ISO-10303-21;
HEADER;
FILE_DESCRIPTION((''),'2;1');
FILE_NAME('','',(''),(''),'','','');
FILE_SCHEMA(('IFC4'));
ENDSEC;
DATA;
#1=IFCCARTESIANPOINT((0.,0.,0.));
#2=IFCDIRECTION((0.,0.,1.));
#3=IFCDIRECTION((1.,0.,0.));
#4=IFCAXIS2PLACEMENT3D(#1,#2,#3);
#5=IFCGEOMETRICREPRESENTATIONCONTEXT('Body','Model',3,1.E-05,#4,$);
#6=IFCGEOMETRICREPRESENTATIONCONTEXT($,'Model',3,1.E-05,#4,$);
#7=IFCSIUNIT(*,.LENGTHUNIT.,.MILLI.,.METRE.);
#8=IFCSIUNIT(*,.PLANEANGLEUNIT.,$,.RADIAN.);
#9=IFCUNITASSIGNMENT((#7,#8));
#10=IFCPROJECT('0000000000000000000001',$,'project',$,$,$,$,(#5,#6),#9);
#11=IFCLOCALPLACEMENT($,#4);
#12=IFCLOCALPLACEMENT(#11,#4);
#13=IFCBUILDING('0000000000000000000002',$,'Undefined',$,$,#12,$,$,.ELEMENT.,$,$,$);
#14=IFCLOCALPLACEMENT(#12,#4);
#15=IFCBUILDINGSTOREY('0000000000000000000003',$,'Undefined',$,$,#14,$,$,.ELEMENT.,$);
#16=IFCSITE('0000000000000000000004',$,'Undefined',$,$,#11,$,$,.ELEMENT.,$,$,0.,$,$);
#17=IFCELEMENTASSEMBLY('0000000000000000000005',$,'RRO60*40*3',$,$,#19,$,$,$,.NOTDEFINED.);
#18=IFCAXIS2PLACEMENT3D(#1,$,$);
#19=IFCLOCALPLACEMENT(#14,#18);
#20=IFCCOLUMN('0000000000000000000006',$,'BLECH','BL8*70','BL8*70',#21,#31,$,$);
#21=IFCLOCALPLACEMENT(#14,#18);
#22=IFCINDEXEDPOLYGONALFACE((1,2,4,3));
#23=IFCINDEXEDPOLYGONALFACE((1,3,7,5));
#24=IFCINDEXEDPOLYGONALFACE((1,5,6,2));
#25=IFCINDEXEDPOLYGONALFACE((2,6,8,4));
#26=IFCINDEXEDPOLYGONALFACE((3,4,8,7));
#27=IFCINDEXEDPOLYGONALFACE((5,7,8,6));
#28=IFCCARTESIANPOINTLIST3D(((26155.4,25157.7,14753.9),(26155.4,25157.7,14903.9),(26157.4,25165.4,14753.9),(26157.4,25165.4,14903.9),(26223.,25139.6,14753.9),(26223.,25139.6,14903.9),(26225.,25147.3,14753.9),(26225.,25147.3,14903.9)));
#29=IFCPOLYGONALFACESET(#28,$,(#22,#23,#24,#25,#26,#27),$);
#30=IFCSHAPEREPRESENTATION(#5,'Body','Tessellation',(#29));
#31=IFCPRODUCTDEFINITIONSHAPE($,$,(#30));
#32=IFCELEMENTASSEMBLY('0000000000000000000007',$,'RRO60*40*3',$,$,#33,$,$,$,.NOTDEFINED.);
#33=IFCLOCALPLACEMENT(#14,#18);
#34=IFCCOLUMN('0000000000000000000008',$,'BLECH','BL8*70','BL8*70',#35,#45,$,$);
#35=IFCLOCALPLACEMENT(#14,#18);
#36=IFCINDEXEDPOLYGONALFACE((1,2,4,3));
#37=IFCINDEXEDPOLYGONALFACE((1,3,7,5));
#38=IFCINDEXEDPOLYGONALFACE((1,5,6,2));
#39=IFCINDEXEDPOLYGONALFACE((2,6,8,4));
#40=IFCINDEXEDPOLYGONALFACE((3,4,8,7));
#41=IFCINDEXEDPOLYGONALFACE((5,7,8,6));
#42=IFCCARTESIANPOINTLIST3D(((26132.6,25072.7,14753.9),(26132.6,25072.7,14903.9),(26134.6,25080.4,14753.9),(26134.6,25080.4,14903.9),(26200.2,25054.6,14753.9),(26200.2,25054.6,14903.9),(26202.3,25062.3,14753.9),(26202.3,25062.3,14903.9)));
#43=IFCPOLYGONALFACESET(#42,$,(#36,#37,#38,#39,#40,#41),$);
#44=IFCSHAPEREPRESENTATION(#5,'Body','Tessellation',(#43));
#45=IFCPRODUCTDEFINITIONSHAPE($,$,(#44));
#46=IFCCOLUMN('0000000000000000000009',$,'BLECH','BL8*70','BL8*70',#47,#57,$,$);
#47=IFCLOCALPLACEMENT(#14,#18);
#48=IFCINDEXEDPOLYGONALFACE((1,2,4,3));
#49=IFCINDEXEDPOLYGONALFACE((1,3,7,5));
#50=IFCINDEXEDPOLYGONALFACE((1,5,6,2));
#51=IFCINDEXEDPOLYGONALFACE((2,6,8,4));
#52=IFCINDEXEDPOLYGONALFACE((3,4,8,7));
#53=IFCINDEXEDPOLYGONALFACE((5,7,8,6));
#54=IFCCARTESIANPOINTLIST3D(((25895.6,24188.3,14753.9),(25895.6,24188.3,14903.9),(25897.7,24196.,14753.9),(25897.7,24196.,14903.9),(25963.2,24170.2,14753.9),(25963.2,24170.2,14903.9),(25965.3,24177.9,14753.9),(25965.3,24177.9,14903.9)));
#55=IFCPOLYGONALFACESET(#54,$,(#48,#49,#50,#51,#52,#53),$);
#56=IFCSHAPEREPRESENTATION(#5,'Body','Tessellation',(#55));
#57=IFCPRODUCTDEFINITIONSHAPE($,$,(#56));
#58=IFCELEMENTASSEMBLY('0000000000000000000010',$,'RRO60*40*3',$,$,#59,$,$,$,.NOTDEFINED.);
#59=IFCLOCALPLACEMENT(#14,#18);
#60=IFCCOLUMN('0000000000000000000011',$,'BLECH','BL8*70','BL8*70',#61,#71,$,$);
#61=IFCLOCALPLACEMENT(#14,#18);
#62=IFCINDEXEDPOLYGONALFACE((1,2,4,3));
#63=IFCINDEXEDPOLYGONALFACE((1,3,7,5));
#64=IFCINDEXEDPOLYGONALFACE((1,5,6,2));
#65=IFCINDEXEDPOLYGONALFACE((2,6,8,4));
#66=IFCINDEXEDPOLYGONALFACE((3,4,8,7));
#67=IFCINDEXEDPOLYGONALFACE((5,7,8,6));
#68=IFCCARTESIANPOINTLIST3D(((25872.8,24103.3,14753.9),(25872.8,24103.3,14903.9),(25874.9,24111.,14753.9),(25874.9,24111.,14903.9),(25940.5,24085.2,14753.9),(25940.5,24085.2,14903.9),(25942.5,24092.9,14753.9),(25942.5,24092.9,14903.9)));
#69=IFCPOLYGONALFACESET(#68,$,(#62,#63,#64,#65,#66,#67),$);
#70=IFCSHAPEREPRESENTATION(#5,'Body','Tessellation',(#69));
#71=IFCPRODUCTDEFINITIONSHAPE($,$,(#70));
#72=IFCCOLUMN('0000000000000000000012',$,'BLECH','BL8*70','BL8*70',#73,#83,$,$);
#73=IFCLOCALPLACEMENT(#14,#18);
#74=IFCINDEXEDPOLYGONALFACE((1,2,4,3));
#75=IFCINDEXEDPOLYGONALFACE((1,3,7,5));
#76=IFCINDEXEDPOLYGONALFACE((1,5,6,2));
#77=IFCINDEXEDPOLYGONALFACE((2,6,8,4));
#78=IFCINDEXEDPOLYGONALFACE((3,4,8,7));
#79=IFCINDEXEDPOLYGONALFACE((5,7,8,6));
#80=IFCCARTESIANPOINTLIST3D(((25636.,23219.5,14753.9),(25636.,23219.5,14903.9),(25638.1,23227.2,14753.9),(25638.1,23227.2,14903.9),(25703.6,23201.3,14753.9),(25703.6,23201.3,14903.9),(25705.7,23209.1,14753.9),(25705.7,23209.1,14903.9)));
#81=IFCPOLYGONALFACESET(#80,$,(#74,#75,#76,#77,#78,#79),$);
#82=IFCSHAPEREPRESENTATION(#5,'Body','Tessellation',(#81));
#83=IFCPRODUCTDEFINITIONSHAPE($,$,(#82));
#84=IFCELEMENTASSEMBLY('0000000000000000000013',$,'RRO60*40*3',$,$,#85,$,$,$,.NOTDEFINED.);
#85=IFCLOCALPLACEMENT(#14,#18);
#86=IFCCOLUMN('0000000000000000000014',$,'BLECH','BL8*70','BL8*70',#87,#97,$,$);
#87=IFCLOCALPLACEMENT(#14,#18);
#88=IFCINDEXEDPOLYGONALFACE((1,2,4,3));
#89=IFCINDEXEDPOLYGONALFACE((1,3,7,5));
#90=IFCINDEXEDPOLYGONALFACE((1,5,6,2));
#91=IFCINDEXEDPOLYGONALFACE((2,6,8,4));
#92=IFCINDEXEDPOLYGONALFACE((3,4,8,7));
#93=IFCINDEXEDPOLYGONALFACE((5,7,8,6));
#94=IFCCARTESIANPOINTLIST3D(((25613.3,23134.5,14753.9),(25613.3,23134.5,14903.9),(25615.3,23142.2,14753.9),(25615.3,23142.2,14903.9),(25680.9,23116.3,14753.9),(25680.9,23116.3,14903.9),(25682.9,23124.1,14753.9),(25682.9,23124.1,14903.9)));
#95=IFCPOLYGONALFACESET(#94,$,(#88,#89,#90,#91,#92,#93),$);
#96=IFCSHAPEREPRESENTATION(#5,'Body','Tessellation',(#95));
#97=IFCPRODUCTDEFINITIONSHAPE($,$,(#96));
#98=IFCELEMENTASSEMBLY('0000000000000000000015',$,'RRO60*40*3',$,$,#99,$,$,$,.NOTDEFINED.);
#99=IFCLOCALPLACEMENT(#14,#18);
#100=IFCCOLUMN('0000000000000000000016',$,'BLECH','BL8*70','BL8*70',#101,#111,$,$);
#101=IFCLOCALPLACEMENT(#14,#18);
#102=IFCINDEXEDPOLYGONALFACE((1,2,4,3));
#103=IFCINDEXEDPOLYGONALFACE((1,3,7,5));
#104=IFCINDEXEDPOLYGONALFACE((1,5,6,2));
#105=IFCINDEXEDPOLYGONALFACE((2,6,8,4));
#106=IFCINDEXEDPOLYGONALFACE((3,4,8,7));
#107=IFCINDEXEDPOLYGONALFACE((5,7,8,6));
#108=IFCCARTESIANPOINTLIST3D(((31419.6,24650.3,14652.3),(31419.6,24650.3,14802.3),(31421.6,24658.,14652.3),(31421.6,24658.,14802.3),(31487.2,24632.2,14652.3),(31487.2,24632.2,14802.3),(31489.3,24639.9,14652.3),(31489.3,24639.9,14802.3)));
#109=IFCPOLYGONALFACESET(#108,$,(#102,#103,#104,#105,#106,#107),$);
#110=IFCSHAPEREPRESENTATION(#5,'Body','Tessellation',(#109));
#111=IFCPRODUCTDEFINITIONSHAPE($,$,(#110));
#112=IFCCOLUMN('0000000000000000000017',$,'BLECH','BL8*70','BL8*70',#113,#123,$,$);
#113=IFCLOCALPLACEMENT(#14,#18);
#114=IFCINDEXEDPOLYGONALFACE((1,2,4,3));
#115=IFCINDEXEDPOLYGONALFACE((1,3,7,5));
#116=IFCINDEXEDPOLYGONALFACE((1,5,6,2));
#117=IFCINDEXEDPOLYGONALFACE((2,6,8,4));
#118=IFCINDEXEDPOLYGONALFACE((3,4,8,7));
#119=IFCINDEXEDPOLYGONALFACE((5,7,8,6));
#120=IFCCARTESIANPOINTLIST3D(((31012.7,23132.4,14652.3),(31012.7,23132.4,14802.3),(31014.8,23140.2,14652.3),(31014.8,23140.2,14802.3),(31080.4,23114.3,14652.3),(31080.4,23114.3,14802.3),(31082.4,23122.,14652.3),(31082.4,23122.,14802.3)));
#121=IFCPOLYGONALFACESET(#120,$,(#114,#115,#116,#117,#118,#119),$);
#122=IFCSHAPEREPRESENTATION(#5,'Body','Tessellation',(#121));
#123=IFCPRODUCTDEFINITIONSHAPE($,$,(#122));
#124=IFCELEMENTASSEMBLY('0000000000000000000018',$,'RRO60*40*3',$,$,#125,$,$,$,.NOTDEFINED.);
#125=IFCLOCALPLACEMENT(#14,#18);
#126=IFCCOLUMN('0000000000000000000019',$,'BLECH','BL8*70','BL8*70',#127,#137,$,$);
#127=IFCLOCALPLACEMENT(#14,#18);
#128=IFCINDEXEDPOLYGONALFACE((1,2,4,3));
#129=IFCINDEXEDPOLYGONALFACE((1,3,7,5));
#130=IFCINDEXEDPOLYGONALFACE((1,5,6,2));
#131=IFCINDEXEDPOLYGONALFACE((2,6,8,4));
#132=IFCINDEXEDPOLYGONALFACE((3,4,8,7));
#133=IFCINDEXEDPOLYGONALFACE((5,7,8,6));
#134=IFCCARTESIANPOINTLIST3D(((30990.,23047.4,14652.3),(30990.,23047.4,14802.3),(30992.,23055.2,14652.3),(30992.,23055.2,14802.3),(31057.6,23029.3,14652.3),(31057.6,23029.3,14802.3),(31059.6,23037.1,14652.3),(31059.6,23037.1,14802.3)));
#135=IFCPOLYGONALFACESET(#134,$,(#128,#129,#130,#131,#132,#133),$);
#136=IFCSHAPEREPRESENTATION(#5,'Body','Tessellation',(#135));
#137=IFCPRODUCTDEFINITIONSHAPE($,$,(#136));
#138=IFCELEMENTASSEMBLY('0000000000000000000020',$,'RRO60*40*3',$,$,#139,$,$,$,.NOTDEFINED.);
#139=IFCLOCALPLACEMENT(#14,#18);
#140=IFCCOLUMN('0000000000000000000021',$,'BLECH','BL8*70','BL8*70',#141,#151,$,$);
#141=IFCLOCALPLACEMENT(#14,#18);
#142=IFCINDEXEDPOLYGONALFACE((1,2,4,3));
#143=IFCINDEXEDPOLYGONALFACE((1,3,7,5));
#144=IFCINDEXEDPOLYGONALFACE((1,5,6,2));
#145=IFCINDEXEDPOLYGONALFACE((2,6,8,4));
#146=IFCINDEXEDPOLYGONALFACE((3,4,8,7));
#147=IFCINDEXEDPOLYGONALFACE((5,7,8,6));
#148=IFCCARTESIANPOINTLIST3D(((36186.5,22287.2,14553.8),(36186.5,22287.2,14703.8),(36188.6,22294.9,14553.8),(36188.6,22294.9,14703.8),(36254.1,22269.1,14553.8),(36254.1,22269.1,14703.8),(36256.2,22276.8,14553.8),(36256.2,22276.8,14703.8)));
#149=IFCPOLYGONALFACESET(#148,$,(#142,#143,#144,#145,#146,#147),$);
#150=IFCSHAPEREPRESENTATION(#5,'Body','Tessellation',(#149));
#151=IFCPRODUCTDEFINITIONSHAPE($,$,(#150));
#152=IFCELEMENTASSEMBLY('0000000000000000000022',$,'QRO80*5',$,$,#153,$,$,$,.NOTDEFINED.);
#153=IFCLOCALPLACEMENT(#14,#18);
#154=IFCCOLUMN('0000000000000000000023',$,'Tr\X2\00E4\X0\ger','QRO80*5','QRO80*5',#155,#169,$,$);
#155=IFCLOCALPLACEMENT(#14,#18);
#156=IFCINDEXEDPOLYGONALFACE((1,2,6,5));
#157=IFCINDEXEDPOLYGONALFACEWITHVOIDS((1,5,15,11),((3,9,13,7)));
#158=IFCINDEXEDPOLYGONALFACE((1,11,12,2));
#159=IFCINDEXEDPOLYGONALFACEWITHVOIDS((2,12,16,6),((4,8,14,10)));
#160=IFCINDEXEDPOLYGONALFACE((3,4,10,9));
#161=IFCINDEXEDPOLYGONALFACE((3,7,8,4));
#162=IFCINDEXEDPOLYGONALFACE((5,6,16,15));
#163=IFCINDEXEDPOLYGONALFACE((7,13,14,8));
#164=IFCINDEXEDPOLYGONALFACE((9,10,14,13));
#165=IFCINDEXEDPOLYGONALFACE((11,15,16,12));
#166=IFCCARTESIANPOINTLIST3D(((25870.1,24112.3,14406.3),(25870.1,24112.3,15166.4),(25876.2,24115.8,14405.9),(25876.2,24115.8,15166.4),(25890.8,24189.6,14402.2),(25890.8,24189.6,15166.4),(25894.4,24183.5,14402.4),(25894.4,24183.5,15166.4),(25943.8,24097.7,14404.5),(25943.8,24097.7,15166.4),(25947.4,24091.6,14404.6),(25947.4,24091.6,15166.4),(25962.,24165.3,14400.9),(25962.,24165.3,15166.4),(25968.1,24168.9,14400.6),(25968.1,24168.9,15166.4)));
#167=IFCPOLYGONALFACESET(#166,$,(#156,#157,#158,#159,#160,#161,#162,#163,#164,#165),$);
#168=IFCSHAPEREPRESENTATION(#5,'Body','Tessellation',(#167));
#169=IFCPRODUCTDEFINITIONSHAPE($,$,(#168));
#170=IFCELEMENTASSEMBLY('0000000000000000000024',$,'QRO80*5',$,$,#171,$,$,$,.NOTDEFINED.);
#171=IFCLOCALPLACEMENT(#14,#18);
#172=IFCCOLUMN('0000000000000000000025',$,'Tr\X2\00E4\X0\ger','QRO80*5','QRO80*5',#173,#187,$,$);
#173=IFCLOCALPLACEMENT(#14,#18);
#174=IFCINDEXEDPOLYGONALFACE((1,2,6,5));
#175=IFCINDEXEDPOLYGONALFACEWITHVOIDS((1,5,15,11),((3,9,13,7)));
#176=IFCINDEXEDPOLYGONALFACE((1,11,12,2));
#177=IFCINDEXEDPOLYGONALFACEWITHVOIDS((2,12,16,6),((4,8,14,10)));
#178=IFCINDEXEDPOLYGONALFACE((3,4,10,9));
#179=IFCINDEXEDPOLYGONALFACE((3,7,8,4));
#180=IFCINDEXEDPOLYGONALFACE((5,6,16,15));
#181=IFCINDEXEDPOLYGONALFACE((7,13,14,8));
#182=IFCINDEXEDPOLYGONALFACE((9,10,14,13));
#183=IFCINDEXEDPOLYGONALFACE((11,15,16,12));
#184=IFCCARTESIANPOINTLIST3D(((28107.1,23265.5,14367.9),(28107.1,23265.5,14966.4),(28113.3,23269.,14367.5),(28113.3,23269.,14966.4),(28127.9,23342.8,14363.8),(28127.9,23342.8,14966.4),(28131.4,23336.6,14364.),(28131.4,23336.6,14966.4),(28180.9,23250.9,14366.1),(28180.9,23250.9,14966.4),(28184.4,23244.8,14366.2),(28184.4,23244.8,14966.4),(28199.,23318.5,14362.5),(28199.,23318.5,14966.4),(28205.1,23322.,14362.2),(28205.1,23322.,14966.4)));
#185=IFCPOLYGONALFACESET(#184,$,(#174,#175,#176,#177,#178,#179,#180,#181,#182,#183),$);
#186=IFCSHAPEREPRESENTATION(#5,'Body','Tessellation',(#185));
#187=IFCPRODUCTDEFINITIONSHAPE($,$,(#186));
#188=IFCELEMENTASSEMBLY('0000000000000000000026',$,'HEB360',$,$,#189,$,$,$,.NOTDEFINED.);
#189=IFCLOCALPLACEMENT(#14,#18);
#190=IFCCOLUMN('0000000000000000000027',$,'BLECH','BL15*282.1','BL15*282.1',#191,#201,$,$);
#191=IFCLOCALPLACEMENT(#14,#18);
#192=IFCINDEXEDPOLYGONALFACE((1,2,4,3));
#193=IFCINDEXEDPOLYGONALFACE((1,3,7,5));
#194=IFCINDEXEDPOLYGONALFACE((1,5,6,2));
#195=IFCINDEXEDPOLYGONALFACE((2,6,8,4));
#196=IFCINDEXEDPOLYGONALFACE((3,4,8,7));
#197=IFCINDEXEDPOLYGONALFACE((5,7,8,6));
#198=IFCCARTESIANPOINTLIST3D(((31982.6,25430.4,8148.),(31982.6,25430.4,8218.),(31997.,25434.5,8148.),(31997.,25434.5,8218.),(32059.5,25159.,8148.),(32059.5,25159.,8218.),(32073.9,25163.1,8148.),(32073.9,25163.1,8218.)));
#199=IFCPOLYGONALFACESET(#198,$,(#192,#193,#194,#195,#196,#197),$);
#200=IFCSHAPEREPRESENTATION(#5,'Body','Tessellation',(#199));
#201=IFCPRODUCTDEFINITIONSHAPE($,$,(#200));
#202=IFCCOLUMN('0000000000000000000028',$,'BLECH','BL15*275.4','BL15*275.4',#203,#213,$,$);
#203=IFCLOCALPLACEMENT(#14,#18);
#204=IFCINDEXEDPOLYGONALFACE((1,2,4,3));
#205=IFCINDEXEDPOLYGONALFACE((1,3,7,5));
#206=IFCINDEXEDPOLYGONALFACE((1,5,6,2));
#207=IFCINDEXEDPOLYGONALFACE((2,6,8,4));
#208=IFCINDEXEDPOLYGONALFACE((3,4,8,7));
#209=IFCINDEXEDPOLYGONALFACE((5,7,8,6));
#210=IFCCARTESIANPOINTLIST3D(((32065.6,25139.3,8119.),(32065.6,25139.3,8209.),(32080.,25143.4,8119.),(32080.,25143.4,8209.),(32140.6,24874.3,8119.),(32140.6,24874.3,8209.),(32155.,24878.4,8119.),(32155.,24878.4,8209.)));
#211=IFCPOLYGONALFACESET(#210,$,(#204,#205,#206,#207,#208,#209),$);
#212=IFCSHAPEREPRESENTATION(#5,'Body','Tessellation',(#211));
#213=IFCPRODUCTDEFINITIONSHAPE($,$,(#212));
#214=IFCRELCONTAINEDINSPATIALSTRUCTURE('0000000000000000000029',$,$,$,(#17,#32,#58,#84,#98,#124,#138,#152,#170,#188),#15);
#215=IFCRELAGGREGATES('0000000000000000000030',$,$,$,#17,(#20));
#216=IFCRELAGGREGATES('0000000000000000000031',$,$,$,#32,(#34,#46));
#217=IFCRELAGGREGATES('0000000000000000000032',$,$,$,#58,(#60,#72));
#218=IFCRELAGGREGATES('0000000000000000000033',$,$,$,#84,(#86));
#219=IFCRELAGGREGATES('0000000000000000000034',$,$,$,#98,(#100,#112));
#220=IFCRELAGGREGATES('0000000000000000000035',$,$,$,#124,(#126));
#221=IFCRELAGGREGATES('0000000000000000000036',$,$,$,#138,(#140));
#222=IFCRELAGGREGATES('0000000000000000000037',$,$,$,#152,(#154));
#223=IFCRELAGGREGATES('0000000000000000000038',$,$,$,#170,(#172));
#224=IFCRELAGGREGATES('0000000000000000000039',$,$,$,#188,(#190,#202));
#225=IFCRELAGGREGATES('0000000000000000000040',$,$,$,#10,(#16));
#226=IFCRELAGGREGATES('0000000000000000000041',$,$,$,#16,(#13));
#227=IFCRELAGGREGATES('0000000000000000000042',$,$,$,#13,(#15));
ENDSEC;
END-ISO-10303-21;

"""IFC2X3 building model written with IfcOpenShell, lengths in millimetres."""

from ifc_helpers import new_model, si_unit, frame, origin_with_axes, origin_2d_with_axis, place, context, project, spatial, rectangle, hollow_rectangle, extrude, clip, halfspace, element, aggregate, save


model = new_model("IFC2X3")

# Units and contexts
model_context_1 = context("Model", 3, precision=1e-05, world=origin_with_axes(), identifier="Body")
model_context_2 = context("Model", 3, precision=1e-05, world=origin_with_axes())
ifc_project = project(units=[si_unit("LENGTHUNIT", "METRE", prefix="MILLI"), si_unit("PLANEANGLEUNIT", "RADIAN")], contexts=[model_context_1, model_context_2])

# Site, building, storey
site_placement = place(None, origin_with_axes())
site = spatial("IfcSite", under=ifc_project, at=site_placement, Name="Undefined", CompositionType="ELEMENT", RefElevation=0.0)
building_placement = place(site_placement, origin_with_axes())
building = spatial("IfcBuilding", under=site, at=building_placement, Name="Undefined", CompositionType="ELEMENT")
storey_placement = place(building_placement, origin_with_axes())
storey = spatial("IfcBuildingStorey", under=building, at=storey_placement, Name="Undefined", CompositionType="ELEMENT")

# Element assembly, column
assembly_1 = element("IfcElementAssembly", 1, inside=storey, Name="RRO60*40*3", PredefinedType="NOTDEFINED")
column_1_placement = place(storey_placement, frame((26190.2, 25152.5, 14753.9), z_axis=(0.0, 0.0, 1.0), x_axis=(1.0, 0.0, 0.0)))
column_1 = element("IfcColumn", 2, at=column_1_placement, Name="BLECH", Description="BL8*70", ObjectType="BL8*70", context=model_context_1, shape_type="SweptSolid", body=[
    extrude(rectangle(XDim=8.0, YDim=70.0, at=origin_2d_with_axis()), frame((0.0, 0.0, 150.0), z_axis=(0.0, 0.0, -1.0), x_axis=(0.258815, 0.965927, 0.000003)), (0.0, 0.0, 1.0), 150.0),
])
aggregate(assembly_1, [column_1])

# Element assemblies, columns
assembly_2 = element("IfcElementAssembly", 3, inside=storey, Name="RRO60*40*3", PredefinedType="NOTDEFINED")
column_2_placement = place(storey_placement, frame((26167.4, 25067.5, 14753.9), z_axis=(0.0, 0.0, 1.0), x_axis=(1.0, 0.0, 0.0)))
column_2 = element("IfcColumn", 4, at=column_2_placement, Name="BLECH", Description="BL8*70", ObjectType="BL8*70", context=model_context_1, shape_type="SweptSolid", body=[
    extrude(rectangle(XDim=8.0, YDim=70.0, at=origin_2d_with_axis()), frame((0.0, 0.0, 150.0), z_axis=(0.0, 0.0, -1.0), x_axis=(-0.258794, -0.965933, -0.000003)), (0.0, 0.0, 1.0), 150.0),
])
column_3_placement = place(storey_placement, frame((25930.5, 24183.1, 14753.9), z_axis=(0.0, 0.0, 1.0), x_axis=(1.0, 0.0, 0.0)))
column_3 = element("IfcColumn", 5, at=column_3_placement, Name="BLECH", Description="BL8*70", ObjectType="BL8*70", context=model_context_1, shape_type="SweptSolid", body=[
    extrude(rectangle(XDim=8.0, YDim=70.0, at=origin_2d_with_axis()), frame((0.0, 0.0, 150.0), z_axis=(0.0, 0.0, -1.0), x_axis=(0.258794, 0.965933, 0.000003)), (0.0, 0.0, 1.0), 150.0),
])
aggregate(assembly_2, [column_2, column_3])
assembly_3 = element("IfcElementAssembly", 6, inside=storey, Name="RRO60*40*3", PredefinedType="NOTDEFINED")
column_4_placement = place(storey_placement, frame((25907.7, 24098.1, 14753.9), z_axis=(0.0, 0.0, 1.0), x_axis=(1.0, 0.0, 0.0)))
column_4 = element("IfcColumn", 7, at=column_4_placement, Name="BLECH", Description="BL8*70", ObjectType="BL8*70", context=model_context_1, shape_type="SweptSolid", body=[
    extrude(rectangle(XDim=8.0, YDim=70.0, at=origin_2d_with_axis()), frame((0.0, 0.0, 150.0), z_axis=(0.0, 0.0, -1.0), x_axis=(-0.258815, -0.965927, -0.000003)), (0.0, 0.0, 1.0), 150.0),
])
column_5_placement = place(storey_placement, frame((25670.9, 23214.3, 14753.9), z_axis=(0.0, 0.0, 1.0), x_axis=(1.0, 0.0, 0.0)))
column_5 = element("IfcColumn", 8, at=column_5_placement, Name="BLECH", Description="BL8*70", ObjectType="BL8*70", context=model_context_1, shape_type="SweptSolid", body=[
    extrude(rectangle(XDim=8.0, YDim=70.0, at=origin_2d_with_axis()), frame((0.0, 0.0, 150.0), z_axis=(0.0, 0.0, -1.0), x_axis=(0.258815, 0.965927, 0.000003)), (0.0, 0.0, 1.0), 150.0),
])
aggregate(assembly_3, [column_4, column_5])

# Element assembly, column
assembly_4 = element("IfcElementAssembly", 9, inside=storey, Name="RRO60*40*3", PredefinedType="NOTDEFINED")
column_6_placement = place(storey_placement, frame((25648.1, 23129.3, 14753.9), z_axis=(0.0, 0.0, 1.0), x_axis=(1.0, 0.0, 0.0)))
column_6 = element("IfcColumn", 10, at=column_6_placement, Name="BLECH", Description="BL8*70", ObjectType="BL8*70", context=model_context_1, shape_type="SweptSolid", body=[
    extrude(rectangle(XDim=8.0, YDim=70.0, at=origin_2d_with_axis()), frame((0.0, 0.0, 150.0), z_axis=(0.0, 0.0, -1.0), x_axis=(-0.258752, -0.965944, -0.000003)), (0.0, 0.0, 1.0), 150.0),
])
aggregate(assembly_4, [column_6])

# Element assembly, columns
assembly_5 = element("IfcElementAssembly", 11, inside=storey, Name="RRO60*40*3", PredefinedType="NOTDEFINED")
column_7_placement = place(storey_placement, frame((31454.4, 24645.1, 14652.3), z_axis=(0.0, 0.0, 1.0), x_axis=(1.0, 0.0, 0.0)))
column_7 = element("IfcColumn", 12, at=column_7_placement, Name="BLECH", Description="BL8*70", ObjectType="BL8*70", context=model_context_1, shape_type="SweptSolid", body=[
    extrude(rectangle(XDim=8.0, YDim=70.0, at=origin_2d_with_axis()), frame((0.0, 0.0, 150.0), z_axis=(0.0, 0.0, -1.0), x_axis=(-0.258894, -0.965906, 0.000004)), (0.0, 0.0, 1.0), 150.0),
])
column_8_placement = place(storey_placement, frame((31047.6, 23127.2, 14652.3), z_axis=(0.0, 0.0, 1.0), x_axis=(1.0, 0.0, 0.0)))
column_8 = element("IfcColumn", 13, at=column_8_placement, Name="BLECH", Description="BL8*70", ObjectType="BL8*70", context=model_context_1, shape_type="SweptSolid", body=[
    extrude(rectangle(XDim=8.0, YDim=70.0, at=origin_2d_with_axis()), frame((0.0, 0.0, 150.0), z_axis=(0.0, 0.0, -1.0), x_axis=(0.258894, 0.965906, -0.000004)), (0.0, 0.0, 1.0), 150.0),
])
aggregate(assembly_5, [column_7, column_8])

# Element assemblies, columns
assembly_6 = element("IfcElementAssembly", 14, inside=storey, Name="RRO60*40*3", PredefinedType="NOTDEFINED")
column_9_placement = place(storey_placement, frame((31024.8, 23042.2, 14652.3), z_axis=(0.0, 0.0, 1.0), x_axis=(1.0, 0.0, 0.0)))
column_9 = element("IfcColumn", 15, at=column_9_placement, Name="BLECH", Description="BL8*70", ObjectType="BL8*70", context=model_context_1, shape_type="SweptSolid", body=[
    extrude(rectangle(XDim=8.0, YDim=70.0, at=origin_2d_with_axis()), frame((0.0, 0.0, 150.0), z_axis=(0.0, 0.0, -1.0), x_axis=(-0.258806, -0.965929, 0.000006)), (0.0, 0.0, 1.0), 150.0),
])
aggregate(assembly_6, [column_9])
assembly_7 = element("IfcElementAssembly", 16, inside=storey, Name="RRO60*40*3", PredefinedType="NOTDEFINED")
column_10_placement = place(storey_placement, frame((36221.4, 22282.0, 14553.8), z_axis=(0.0, 0.0, 1.0), x_axis=(1.0, 0.0, 0.0)))
column_10 = element("IfcColumn", 17, at=column_10_placement, Name="BLECH", Description="BL8*70", ObjectType="BL8*70", context=model_context_1, shape_type="SweptSolid", body=[
    extrude(rectangle(XDim=8.0, YDim=70.0, at=origin_2d_with_axis()), frame((0.0, 0.0, 150.0), z_axis=(0.0, 0.0, -1.0), x_axis=(-0.258971, -0.965885, 0.000006)), (0.0, 0.0, 1.0), 150.0),
])
aggregate(assembly_7, [column_10])
assembly_8 = element("IfcElementAssembly", 18, inside=storey, Name="QRO80*5", PredefinedType="NOTDEFINED")
column_11_placement = place(storey_placement, frame((25919.1, 24140.6, 14441.2), z_axis=(0.0, 0.0, 1.0), x_axis=(1.0, 0.0, 0.0)))
column_11 = element("IfcColumn", 19, at=column_11_placement, Name="Träger", Description="QRO80*5", ObjectType="QRO80*5", context=model_context_1, shape_type="Clipping", body=[
    clip(clip(extrude(hollow_rectangle(XDim=80.0, YDim=80.0, WallThickness=5.0, at=origin_2d_with_axis()), frame((0.0, 0.0, 725.2), z_axis=(0.0, 0.0, -1.0), x_axis=(-0.25892, -0.965899, 0.000004)), (0.0, 0.0, 1.0), 765.8), halfspace(frame((38.6, -10.4, -38.6), z_axis=(0.033217, 0.043463, 0.998503), x_axis=(-0.257575, -0.964934, 0.05057)), True)), halfspace(frame((-38.6, 10.4, 725.2), z_axis=(0.0, 0.0, -1.0), x_axis=(-0.258815, -0.965927, -0.000003)), True)),
])
aggregate(assembly_8, [column_11])
assembly_9 = element("IfcElementAssembly", 20, inside=storey, Name="QRO80*5", PredefinedType="NOTDEFINED")
column_12_placement = place(storey_placement, frame((28156.1, 23293.8, 14441.2), z_axis=(0.0, 0.0, 1.0), x_axis=(1.0, 0.0, 0.0)))
column_12 = element("IfcColumn", 21, at=column_12_placement, Name="Träger", Description="QRO80*5", ObjectType="QRO80*5", context=model_context_1, shape_type="Clipping", body=[
    clip(clip(extrude(hollow_rectangle(XDim=80.0, YDim=80.0, WallThickness=5.0, at=origin_2d_with_axis()), frame((0.0, 0.0, 525.2), z_axis=(0.0, 0.0, -1.0), x_axis=(-0.25892, -0.965899, 0.000004)), (0.0, 0.0, 1.0), 604.2), halfspace(frame((38.6, -10.4, -77.0), z_axis=(0.033191, 0.043364, 0.998508), x_axis=(-0.257573, -0.96494, 0.050468)), True)), halfspace(frame((38.6, -10.3, 525.2), z_axis=(0.0, 0.0, -1.0), x_axis=(0.258815, 0.965927, 0.000003)), True)),
])
aggregate(assembly_9, [column_12])

# Element assembly, columns
assembly_10 = element("IfcElementAssembly", 22, inside=storey, Name="HEB360", PredefinedType="NOTDEFINED")
column_13_placement = place(storey_placement, frame((32028.3, 25296.8, 8148.0), z_axis=(0.0, 0.0, 1.0), x_axis=(1.0, 0.0, 0.0)))
column_13 = element("IfcColumn", 23, at=column_13_placement, Name="BLECH", Description="BL15*282.1", ObjectType="BL15*282.1", context=model_context_1, shape_type="SweptSolid", body=[
    extrude(rectangle(XDim=15.0, YDim=282.1, at=origin_2d_with_axis()), frame((0.0, 0.0, 70.0), z_axis=(0.0, 0.0, -1.0), x_axis=(0.96217, 0.272448, 0.0)), (0.0, 0.0, 1.0), 70.0),
])
column_14_placement = place(storey_placement, frame((32110.3, 25008.9, 8119.0), z_axis=(0.0, 0.0, 1.0), x_axis=(1.0, 0.0, 0.0)))
column_14 = element("IfcColumn", 24, at=column_14_placement, Name="BLECH", Description="BL15*275.4", ObjectType="BL15*275.4", context=model_context_1, shape_type="SweptSolid", body=[
    extrude(rectangle(XDim=15.0, YDim=275.4, at=origin_2d_with_axis()), frame((0.0, 0.0, 90.0), z_axis=(0.0, 0.0, -1.0), x_axis=(-0.96217, -0.272448, 0.0)), (0.0, 0.0, 1.0), 90.0),
])
aggregate(assembly_10, [column_13, column_14])

save(model, "model.ifc")
